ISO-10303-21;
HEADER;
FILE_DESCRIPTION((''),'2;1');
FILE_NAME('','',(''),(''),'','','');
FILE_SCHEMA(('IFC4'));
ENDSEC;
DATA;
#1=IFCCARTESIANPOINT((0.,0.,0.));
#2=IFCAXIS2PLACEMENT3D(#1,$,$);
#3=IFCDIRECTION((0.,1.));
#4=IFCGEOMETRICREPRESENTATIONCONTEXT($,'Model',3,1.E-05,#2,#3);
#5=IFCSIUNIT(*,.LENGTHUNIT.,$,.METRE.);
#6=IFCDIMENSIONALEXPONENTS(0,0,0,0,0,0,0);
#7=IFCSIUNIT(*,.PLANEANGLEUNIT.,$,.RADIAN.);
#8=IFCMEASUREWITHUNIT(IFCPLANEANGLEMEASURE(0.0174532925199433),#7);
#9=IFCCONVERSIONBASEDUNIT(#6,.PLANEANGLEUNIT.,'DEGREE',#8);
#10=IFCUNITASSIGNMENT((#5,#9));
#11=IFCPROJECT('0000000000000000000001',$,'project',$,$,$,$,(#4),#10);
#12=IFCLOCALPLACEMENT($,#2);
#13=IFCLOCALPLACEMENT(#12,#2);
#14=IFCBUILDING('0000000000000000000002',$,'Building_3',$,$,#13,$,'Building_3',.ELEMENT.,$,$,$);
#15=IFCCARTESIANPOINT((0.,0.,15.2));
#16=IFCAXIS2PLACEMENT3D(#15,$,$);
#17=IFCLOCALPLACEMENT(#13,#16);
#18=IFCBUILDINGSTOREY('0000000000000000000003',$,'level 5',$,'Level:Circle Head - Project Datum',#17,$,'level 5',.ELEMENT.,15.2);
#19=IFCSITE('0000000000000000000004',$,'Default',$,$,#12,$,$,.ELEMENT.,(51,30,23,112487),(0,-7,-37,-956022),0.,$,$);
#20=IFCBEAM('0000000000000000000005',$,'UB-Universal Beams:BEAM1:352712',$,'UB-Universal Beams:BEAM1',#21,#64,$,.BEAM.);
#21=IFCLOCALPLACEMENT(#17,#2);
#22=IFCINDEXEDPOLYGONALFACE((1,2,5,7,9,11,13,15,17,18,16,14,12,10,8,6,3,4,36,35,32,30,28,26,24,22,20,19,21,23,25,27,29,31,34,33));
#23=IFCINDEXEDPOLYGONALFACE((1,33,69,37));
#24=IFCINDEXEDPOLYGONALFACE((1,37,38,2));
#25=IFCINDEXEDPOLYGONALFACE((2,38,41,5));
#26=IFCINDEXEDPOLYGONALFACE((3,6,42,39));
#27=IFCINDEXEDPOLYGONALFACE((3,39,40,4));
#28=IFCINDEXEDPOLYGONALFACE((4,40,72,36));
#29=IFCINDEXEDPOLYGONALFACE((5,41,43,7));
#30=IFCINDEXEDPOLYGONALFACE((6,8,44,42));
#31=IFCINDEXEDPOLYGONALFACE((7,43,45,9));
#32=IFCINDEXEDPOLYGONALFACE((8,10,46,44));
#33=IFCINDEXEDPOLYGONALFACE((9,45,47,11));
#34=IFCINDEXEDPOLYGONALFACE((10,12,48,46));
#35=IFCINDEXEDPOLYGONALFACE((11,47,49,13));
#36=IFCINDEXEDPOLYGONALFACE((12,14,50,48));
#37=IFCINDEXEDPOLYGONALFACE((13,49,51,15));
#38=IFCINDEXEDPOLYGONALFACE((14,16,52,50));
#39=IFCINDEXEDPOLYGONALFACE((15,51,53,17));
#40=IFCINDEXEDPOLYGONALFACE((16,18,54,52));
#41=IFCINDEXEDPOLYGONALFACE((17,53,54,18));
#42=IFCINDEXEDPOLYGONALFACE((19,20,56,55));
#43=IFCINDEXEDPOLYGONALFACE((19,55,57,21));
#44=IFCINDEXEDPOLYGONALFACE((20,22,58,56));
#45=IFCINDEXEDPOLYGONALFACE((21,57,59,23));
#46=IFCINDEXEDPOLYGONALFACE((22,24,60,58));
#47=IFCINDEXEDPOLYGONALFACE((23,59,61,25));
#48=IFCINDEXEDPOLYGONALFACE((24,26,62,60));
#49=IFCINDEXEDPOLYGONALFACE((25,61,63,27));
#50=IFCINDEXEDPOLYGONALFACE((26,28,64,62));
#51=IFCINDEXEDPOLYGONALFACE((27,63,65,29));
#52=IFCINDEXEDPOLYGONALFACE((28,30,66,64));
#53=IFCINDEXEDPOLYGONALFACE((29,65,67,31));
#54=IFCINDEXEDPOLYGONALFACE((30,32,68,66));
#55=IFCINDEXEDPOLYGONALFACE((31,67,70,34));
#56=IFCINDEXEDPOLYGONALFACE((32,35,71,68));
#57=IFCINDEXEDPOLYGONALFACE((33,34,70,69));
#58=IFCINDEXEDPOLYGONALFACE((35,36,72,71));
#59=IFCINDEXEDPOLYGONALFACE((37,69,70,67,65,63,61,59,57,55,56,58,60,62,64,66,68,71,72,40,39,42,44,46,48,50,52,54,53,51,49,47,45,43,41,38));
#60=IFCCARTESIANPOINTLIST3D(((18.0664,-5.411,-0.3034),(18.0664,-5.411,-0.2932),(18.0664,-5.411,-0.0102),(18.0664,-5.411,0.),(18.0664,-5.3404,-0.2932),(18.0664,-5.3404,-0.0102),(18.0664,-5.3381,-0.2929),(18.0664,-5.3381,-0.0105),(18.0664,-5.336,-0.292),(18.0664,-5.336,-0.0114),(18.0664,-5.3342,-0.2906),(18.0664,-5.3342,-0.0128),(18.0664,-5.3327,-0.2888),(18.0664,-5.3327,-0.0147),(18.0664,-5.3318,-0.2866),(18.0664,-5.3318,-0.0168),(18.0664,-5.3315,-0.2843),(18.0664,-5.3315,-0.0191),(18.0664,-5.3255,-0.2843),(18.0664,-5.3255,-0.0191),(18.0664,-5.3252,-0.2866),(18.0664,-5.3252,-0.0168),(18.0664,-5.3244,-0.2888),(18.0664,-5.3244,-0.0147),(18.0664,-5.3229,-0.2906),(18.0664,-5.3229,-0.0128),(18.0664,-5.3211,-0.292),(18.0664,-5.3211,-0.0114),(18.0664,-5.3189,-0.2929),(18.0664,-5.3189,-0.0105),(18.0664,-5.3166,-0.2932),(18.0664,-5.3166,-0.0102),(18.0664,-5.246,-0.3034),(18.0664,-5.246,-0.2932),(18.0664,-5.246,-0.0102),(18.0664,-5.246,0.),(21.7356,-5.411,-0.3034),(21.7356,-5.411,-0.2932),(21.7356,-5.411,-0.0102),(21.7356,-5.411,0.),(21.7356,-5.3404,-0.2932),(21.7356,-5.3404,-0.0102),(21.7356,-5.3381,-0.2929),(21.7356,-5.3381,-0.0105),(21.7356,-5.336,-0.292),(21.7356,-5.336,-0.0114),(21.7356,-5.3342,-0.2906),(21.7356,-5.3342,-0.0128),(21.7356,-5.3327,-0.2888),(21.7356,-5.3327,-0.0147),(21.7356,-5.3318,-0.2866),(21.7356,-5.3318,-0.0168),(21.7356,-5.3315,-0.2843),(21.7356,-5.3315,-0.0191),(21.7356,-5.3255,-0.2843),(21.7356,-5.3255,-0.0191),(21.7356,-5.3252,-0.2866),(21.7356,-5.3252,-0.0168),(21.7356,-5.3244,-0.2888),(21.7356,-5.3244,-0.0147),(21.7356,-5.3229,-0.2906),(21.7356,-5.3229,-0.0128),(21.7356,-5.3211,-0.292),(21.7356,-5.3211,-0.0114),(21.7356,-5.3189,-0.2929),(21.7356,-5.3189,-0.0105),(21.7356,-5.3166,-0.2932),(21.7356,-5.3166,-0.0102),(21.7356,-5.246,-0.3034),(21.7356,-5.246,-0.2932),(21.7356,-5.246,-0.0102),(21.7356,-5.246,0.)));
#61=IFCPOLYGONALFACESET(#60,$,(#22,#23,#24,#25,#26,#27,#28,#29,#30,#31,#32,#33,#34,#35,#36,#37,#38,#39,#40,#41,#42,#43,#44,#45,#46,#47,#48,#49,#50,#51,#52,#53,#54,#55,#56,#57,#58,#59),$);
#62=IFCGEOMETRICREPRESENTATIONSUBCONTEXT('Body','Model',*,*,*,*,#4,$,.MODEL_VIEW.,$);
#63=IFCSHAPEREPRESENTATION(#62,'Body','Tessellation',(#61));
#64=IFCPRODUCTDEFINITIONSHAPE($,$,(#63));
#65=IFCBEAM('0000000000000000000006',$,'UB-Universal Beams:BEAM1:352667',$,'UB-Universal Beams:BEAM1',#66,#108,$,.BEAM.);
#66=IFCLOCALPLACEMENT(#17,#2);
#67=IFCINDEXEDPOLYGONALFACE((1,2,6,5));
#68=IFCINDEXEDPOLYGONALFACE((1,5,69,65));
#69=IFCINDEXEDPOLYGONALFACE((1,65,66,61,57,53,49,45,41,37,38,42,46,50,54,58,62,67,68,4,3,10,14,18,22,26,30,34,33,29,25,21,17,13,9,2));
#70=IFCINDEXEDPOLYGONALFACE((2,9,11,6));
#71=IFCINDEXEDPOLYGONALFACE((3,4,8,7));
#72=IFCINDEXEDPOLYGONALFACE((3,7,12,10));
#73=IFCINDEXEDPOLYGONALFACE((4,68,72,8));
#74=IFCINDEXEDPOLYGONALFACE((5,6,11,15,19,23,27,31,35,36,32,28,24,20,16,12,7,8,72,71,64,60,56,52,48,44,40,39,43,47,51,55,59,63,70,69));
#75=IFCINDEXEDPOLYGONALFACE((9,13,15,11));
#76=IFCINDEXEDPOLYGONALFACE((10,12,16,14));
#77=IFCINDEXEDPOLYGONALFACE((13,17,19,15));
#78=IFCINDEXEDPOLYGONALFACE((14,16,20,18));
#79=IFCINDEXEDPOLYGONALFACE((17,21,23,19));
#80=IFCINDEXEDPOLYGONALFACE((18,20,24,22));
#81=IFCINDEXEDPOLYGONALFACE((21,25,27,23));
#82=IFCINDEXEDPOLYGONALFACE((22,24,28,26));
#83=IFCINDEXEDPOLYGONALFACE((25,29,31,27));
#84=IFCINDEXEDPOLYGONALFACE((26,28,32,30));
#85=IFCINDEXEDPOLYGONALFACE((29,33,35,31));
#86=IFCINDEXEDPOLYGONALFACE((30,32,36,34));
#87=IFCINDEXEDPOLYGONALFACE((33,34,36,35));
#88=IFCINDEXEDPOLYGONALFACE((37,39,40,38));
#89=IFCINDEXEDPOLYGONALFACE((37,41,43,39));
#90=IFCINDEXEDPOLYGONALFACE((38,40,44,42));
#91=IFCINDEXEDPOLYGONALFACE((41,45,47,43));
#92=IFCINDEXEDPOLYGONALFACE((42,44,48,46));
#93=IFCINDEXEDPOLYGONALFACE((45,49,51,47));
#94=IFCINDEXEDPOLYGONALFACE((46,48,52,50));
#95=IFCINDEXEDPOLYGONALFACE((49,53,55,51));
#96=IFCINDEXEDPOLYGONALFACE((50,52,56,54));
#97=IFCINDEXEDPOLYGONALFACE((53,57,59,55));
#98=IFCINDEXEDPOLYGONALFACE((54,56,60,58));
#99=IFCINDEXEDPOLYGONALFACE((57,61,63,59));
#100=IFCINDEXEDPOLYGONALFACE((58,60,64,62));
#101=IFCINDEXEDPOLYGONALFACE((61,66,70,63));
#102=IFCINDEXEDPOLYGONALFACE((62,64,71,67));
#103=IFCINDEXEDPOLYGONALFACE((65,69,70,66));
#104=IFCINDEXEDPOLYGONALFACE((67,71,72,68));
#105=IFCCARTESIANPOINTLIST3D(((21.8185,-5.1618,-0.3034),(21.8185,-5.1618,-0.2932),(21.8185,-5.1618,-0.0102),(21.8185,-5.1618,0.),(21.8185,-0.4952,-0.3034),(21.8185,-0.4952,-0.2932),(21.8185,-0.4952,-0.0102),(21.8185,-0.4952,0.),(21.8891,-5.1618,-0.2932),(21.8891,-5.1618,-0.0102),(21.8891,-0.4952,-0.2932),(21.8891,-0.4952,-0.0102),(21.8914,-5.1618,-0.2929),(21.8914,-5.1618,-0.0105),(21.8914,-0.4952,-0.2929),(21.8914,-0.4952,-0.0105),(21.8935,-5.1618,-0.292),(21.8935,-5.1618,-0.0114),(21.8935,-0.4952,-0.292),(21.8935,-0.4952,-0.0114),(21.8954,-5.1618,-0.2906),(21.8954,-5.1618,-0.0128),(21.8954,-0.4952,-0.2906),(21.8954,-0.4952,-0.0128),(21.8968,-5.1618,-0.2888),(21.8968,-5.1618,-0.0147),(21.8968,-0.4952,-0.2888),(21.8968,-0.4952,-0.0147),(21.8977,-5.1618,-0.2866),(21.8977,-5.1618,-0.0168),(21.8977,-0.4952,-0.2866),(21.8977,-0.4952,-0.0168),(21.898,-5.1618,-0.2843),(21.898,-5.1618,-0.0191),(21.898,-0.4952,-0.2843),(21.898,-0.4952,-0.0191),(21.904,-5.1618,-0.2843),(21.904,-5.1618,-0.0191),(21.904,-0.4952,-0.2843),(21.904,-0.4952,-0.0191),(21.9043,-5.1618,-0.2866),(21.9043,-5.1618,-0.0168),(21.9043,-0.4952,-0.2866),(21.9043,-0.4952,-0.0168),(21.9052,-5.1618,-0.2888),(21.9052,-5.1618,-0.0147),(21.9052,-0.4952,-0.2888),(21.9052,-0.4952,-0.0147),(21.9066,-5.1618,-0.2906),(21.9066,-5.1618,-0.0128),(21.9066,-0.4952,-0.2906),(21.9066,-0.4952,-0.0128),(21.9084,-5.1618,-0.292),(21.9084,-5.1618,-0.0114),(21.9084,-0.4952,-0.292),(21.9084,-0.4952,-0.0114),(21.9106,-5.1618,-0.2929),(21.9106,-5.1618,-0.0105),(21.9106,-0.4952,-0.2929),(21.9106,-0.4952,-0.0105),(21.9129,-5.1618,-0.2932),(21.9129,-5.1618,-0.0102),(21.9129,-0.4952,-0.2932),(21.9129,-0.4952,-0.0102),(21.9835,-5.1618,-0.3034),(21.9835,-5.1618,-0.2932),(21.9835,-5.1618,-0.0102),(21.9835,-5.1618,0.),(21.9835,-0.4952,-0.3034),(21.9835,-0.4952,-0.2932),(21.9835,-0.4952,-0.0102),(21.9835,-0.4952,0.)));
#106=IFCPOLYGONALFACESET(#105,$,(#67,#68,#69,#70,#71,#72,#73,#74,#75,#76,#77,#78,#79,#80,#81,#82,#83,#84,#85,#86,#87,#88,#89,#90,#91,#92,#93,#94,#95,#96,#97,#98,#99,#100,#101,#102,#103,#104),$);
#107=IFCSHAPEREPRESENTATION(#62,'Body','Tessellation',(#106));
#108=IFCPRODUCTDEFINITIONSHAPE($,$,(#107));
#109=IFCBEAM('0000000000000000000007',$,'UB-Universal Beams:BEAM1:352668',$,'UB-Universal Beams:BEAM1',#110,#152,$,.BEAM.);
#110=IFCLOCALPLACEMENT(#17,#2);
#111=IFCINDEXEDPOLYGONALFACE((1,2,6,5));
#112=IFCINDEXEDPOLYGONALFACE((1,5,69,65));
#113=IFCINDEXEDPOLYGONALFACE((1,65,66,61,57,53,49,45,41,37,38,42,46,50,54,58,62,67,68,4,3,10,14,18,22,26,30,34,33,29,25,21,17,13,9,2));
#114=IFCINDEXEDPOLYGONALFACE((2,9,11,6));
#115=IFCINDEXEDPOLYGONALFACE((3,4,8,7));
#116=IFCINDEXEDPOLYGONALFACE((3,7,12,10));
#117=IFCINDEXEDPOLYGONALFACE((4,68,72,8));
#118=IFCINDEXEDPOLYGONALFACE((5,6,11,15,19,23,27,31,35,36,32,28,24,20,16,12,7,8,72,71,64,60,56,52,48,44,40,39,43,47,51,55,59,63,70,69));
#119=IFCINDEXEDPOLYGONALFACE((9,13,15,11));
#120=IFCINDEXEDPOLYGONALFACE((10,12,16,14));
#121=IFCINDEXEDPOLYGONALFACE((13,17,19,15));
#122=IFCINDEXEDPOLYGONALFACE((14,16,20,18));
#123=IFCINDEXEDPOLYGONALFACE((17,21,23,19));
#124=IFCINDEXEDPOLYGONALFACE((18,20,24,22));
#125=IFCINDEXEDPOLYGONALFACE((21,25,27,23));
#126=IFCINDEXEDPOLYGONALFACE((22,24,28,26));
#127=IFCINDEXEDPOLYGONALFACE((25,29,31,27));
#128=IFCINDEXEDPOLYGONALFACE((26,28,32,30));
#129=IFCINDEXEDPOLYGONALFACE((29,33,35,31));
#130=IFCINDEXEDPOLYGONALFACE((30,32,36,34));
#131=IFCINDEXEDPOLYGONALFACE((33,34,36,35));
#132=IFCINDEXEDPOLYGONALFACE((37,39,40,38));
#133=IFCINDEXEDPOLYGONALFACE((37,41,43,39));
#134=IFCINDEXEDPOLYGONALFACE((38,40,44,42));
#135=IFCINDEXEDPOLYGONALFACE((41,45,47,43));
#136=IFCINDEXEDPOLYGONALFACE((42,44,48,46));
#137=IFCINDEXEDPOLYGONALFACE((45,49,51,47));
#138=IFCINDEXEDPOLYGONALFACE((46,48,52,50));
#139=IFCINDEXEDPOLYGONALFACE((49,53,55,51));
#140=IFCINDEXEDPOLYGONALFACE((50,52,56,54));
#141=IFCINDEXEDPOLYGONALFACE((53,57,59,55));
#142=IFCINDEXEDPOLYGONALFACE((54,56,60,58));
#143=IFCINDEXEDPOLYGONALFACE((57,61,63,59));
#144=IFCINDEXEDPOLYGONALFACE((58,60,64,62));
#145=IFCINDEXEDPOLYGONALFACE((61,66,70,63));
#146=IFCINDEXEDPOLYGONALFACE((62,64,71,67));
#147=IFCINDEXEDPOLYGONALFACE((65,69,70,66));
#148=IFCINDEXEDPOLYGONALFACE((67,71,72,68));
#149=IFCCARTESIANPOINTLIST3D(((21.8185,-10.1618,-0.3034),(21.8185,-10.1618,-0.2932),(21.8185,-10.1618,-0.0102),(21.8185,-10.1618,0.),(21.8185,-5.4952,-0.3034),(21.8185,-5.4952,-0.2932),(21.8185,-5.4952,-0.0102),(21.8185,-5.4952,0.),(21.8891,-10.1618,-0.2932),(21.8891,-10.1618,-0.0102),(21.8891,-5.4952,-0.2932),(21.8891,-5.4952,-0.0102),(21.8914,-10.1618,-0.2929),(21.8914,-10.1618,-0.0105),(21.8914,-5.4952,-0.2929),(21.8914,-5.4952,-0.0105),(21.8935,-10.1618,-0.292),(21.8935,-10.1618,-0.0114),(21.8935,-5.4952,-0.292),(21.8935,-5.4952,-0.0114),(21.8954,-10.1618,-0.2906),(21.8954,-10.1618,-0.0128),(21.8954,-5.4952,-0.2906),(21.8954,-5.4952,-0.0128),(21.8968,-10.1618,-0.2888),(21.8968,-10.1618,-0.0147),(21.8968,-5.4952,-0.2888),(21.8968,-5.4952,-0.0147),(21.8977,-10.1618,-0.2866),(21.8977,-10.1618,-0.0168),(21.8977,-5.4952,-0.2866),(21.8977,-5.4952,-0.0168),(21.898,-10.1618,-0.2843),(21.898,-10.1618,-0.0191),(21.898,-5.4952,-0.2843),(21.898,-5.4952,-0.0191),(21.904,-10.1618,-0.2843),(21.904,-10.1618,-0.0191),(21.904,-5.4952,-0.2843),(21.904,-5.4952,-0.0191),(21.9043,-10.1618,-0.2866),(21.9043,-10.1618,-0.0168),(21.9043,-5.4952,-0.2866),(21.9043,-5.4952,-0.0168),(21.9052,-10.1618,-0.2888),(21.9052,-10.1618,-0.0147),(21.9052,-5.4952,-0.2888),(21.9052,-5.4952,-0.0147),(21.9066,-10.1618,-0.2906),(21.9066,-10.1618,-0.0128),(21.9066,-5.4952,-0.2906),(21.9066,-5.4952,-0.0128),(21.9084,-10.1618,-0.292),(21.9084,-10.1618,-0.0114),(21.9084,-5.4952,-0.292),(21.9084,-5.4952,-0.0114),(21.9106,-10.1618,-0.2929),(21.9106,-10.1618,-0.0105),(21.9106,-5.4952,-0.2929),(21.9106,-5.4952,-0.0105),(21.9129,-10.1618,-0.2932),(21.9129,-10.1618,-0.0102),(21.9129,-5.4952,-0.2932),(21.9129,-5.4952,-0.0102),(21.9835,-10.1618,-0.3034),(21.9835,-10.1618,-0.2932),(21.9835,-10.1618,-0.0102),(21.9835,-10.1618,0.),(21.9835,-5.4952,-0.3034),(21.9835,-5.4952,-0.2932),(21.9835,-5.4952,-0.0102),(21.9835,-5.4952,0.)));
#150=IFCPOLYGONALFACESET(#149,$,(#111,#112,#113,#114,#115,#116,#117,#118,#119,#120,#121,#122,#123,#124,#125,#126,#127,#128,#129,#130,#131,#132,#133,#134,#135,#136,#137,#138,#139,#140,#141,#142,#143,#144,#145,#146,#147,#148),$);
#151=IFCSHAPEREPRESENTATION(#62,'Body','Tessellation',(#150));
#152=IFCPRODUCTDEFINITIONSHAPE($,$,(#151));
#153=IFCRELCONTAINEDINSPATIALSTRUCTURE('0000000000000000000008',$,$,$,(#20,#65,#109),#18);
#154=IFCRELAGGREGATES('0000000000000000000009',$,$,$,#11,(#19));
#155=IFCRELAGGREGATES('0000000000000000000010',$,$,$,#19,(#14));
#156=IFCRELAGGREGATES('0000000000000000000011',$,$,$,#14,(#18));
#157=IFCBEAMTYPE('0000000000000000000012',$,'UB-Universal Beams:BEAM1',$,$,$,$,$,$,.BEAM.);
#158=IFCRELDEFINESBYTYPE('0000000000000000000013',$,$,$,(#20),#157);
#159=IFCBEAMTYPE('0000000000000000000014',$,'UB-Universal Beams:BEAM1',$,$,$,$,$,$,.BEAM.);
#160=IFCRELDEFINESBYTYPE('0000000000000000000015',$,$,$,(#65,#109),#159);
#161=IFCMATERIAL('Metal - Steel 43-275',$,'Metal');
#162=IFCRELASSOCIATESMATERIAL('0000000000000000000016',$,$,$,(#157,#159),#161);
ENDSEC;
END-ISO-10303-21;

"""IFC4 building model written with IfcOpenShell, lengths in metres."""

from ifc_helpers import new_model, entity, si_unit, converted_unit, direction, frame, frame_2d, origin, place, context, subcontext, project, spatial, polyline, circle_curve, parameter, trimmed, segment, composite_curve, outline, extrude, source, transform, mapped, material, material_profile, profile_set, type_object, type_shapes, element, save


model = new_model("IFC4")

# Units and contexts
model_context = context("Model", 3, precision=1e-05, world=origin(), true_north=direction((0.0, 1.0)))
body_context = subcontext(model_context, "Body", "Model", "MODEL_VIEW")
ifc_project = project(units=[si_unit("LENGTHUNIT", "METRE"), converted_unit("PLANEANGLEUNIT", "DEGREE", entity("IfcPlaneAngleMeasure", 0.0174532925199433), si_unit("PLANEANGLEUNIT", "RADIAN"), dimensions=[0, 0, 0, 0, 0, 0, 0])], contexts=[model_context])

# Site, building, storey
site_placement = place(None, origin())
site = spatial("IfcSite", under=ifc_project, at=site_placement, Name="Default", CompositionType="ELEMENT", RefLatitude=(51, 30, 23, 112487), RefLongitude=(0, -7, -37, -956022), RefElevation=0.0)
building_placement = place(site_placement, origin())
building = spatial("IfcBuilding", under=site, at=building_placement, Name="Building_3", LongName="Building_3", CompositionType="ELEMENT")
storey_placement = place(building_placement, frame((0.0, 0.0, 15.2)))
storey = spatial("IfcBuildingStorey", under=building, at=storey_placement, Name="level 5", ObjectType="Level:Circle Head - Project Datum", LongName="level 5", CompositionType="ELEMENT", Elevation=15.2)

# Beams
ifc_material_1 = material(Name="Metal - Steel 43-275", Category="Metal")
ifc_material_profile = material_profile(ifc_material_1, outline(composite_curve([segment(polyline([(-0.0825, -0.1415), (-0.0825, -0.1517)]), True, "CONTINUOUS"), segment(polyline([(-0.0825, -0.1517), (0.0825, -0.1517)]), True, "CONTINUOUS"), segment(polyline([(0.0825, -0.1517), (0.0825, -0.1415)]), True, "CONTINUOUS"), segment(polyline([(0.0825, -0.1415), (0.0119, -0.1415)]), True, "CONTINUOUS"), segment(trimmed(circle_curve(frame_2d((0.0119, -0.1326), x_axis=(1.0, 0.0)), 0.0089), [parameter(180.0)], [parameter(270.0)], True, "PARAMETER"), False, "CONTINUOUS"), segment(polyline([(0.003, -0.1326), (0.003, 0.1326)]), True, "CONTINUOUS"), segment(trimmed(circle_curve(frame_2d((0.0119, 0.1326), x_axis=(1.0, 0.0)), 0.0089), [parameter(90.0)], [parameter(180.0)], True, "PARAMETER"), False, "CONTINUOUS"), segment(polyline([(0.0119, 0.1415), (0.0825, 0.1415)]), True, "CONTINUOUS"), segment(polyline([(0.0825, 0.1415), (0.0825, 0.1517)]), True, "CONTINUOUS"), segment(polyline([(0.0825, 0.1517), (-0.0825, 0.1517)]), True, "CONTINUOUS"), segment(polyline([(-0.0825, 0.1517), (-0.0825, 0.1415)]), True, "CONTINUOUS"), segment(polyline([(-0.0825, 0.1415), (-0.0119, 0.1415)]), True, "CONTINUOUS"), segment(trimmed(circle_curve(frame_2d((-0.0119, 0.1326), x_axis=(1.0, 0.0)), 0.0089), [parameter(360.0)], [parameter(90.0)], True, "PARAMETER"), False, "CONTINUOUS"), segment(polyline([(-0.003, 0.1326), (-0.003, -0.1326)]), True, "CONTINUOUS"), segment(trimmed(circle_curve(frame_2d((-0.0119, -0.1326), x_axis=(1.0, 0.0)), 0.0089), [parameter(270.0)], [parameter(360.0)], True, "PARAMETER"), False, "CONTINUOUS"), segment(polyline([(-0.0119, -0.1415), (-0.0825, -0.1415)]), True, "CONTINUOUS")], self_intersect=False)), Name="BEAM1")
ifc_profile_set = profile_set([ifc_material_profile], Name="BEAM1")
beam_type_1 = type_object("IfcBeamType", Name="UB-Universal Beams:BEAM1", PredefinedType="BEAM", material=ifc_profile_set)
shared_shape_1 = source(origin(), body_context, "Body", "SweptSolid", [
    extrude(outline(composite_curve([segment(polyline([(-0.0825, -0.1415), (-0.0825, -0.1517)]), True, "CONTINUOUS"), segment(polyline([(-0.0825, -0.1517), (0.0825, -0.1517)]), True, "CONTINUOUS"), segment(polyline([(0.0825, -0.1517), (0.0825, -0.1415)]), True, "CONTINUOUS"), segment(polyline([(0.0825, -0.1415), (0.0119, -0.1415)]), True, "CONTINUOUS"), segment(trimmed(circle_curve(frame_2d((0.0119, -0.1326), x_axis=(0.0, -1.0)), 0.0089), [parameter(270.0)], [parameter(360.0)], True, "PARAMETER"), False, "CONTINUOUS"), segment(polyline([(0.003, -0.1326), (0.003, 0.1326)]), True, "CONTINUOUS"), segment(trimmed(circle_curve(frame_2d((0.0119, 0.1326), x_axis=(-1.0, 0.0)), 0.0089), [parameter(270.0)], [parameter(360.0)], True, "PARAMETER"), False, "CONTINUOUS"), segment(polyline([(0.0119, 0.1415), (0.0825, 0.1415)]), True, "CONTINUOUS"), segment(polyline([(0.0825, 0.1415), (0.0825, 0.1517)]), True, "CONTINUOUS"), segment(polyline([(0.0825, 0.1517), (-0.0825, 0.1517)]), True, "CONTINUOUS"), segment(polyline([(-0.0825, 0.1517), (-0.0825, 0.1415)]), True, "CONTINUOUS"), segment(polyline([(-0.0825, 0.1415), (-0.0119, 0.1415)]), True, "CONTINUOUS"), segment(trimmed(circle_curve(frame_2d((-0.0119, 0.1326), x_axis=(0.0, 1.0)), 0.0089), [parameter(270.0)], [parameter(360.0)], True, "PARAMETER"), False, "CONTINUOUS"), segment(polyline([(-0.003, 0.1326), (-0.003, -0.1326)]), True, "CONTINUOUS"), segment(trimmed(circle_curve(frame_2d((-0.0119, -0.1326), x_axis=(1.0, 0.0)), 0.0089), [parameter(270.0)], [parameter(0.0)], True, "PARAMETER"), False, "CONTINUOUS"), segment(polyline([(-0.0119, -0.1415), (-0.0825, -0.1415)]), True, "CONTINUOUS")], self_intersect=False)), frame((-1.8346, 0.0, 0.0), z_axis=(-1.0, 0.0, 0.0), x_axis=(0.0, -1.0, 0.0)), (0.0, 0.0, -1.0), 3.6692),
])
type_shapes(beam_type_1, [shared_shape_1])
for number, where, name in (
    (1, (19.901, -5.3285, -0.1517), "UB-Universal Beams:BEAM1:352712"),
):
    element("IfcBeam", number, at=place(storey_placement, frame(where)), inside=storey, type_object=beam_type_1, Name=name, ObjectType="UB-Universal Beams:BEAM1", PredefinedType="BEAM", context=body_context, shape_type="MappedRepresentation", body=[
        mapped(shared_shape_1, transform((0.0, 0.0, 0.0), scale=1.0)),
    ])
beam_type_2 = type_object("IfcBeamType", Name="UB-Universal Beams:BEAM1", PredefinedType="BEAM", material=ifc_profile_set)
shared_shape_2 = source(origin(), body_context, "Body", "SweptSolid", [
    extrude(outline(composite_curve([segment(polyline([(-0.0825, -0.1415), (-0.0825, -0.1517)]), True, "CONTINUOUS"), segment(polyline([(-0.0825, -0.1517), (0.0825, -0.1517)]), True, "CONTINUOUS"), segment(polyline([(0.0825, -0.1517), (0.0825, -0.1415)]), True, "CONTINUOUS"), segment(polyline([(0.0825, -0.1415), (0.0119, -0.1415)]), True, "CONTINUOUS"), segment(trimmed(circle_curve(frame_2d((0.0119, -0.1326), x_axis=(0.0, -1.0)), 0.0089), [parameter(270.0)], [parameter(360.0)], True, "PARAMETER"), False, "CONTINUOUS"), segment(polyline([(0.003, -0.1326), (0.003, 0.1326)]), True, "CONTINUOUS"), segment(trimmed(circle_curve(frame_2d((0.0119, 0.1326), x_axis=(-1.0, 0.0)), 0.0089), [parameter(270.0)], [parameter(360.0)], True, "PARAMETER"), False, "CONTINUOUS"), segment(polyline([(0.0119, 0.1415), (0.0825, 0.1415)]), True, "CONTINUOUS"), segment(polyline([(0.0825, 0.1415), (0.0825, 0.1517)]), True, "CONTINUOUS"), segment(polyline([(0.0825, 0.1517), (-0.0825, 0.1517)]), True, "CONTINUOUS"), segment(polyline([(-0.0825, 0.1517), (-0.0825, 0.1415)]), True, "CONTINUOUS"), segment(polyline([(-0.0825, 0.1415), (-0.0119, 0.1415)]), True, "CONTINUOUS"), segment(trimmed(circle_curve(frame_2d((-0.0119, 0.1326), x_axis=(0.0, 1.0)), 0.0089), [parameter(270.0)], [parameter(360.0)], True, "PARAMETER"), False, "CONTINUOUS"), segment(polyline([(-0.003, 0.1326), (-0.003, -0.1326)]), True, "CONTINUOUS"), segment(trimmed(circle_curve(frame_2d((-0.0119, -0.1326), x_axis=(1.0, 0.0)), 0.0089), [parameter(270.0)], [parameter(0.0)], True, "PARAMETER"), False, "CONTINUOUS"), segment(polyline([(-0.0119, -0.1415), (-0.0825, -0.1415)]), True, "CONTINUOUS")], self_intersect=False)), frame((-2.3333, 0.0, 0.0), z_axis=(-1.0, 0.0, 0.0), x_axis=(0.0, -1.0, 0.0)), (0.0, 0.0, -1.0), 4.6666),
])
type_shapes(beam_type_2, [shared_shape_2])
for number, where, z_axis, x_axis, name in (
    (2, (21.901, -2.8285, -0.1517), (0.0, 0.0, 1.0), (0.0, -1.0, 0.0), "UB-Universal Beams:BEAM1:352667"),
    (3, (21.901, -7.8285, -0.1517), (0.0, 0.0, 1.0), (0.0, 1.0, 0.0), "UB-Universal Beams:BEAM1:352668"),
):
    element("IfcBeam", number, at=place(storey_placement, frame(where, z_axis=z_axis, x_axis=x_axis)), inside=storey, type_object=beam_type_2, Name=name, ObjectType="UB-Universal Beams:BEAM1", PredefinedType="BEAM", context=body_context, shape_type="MappedRepresentation", body=[
        mapped(shared_shape_2, transform((0.0, 0.0, 0.0), scale=1.0)),
    ])

save(model, "model.ifc")
